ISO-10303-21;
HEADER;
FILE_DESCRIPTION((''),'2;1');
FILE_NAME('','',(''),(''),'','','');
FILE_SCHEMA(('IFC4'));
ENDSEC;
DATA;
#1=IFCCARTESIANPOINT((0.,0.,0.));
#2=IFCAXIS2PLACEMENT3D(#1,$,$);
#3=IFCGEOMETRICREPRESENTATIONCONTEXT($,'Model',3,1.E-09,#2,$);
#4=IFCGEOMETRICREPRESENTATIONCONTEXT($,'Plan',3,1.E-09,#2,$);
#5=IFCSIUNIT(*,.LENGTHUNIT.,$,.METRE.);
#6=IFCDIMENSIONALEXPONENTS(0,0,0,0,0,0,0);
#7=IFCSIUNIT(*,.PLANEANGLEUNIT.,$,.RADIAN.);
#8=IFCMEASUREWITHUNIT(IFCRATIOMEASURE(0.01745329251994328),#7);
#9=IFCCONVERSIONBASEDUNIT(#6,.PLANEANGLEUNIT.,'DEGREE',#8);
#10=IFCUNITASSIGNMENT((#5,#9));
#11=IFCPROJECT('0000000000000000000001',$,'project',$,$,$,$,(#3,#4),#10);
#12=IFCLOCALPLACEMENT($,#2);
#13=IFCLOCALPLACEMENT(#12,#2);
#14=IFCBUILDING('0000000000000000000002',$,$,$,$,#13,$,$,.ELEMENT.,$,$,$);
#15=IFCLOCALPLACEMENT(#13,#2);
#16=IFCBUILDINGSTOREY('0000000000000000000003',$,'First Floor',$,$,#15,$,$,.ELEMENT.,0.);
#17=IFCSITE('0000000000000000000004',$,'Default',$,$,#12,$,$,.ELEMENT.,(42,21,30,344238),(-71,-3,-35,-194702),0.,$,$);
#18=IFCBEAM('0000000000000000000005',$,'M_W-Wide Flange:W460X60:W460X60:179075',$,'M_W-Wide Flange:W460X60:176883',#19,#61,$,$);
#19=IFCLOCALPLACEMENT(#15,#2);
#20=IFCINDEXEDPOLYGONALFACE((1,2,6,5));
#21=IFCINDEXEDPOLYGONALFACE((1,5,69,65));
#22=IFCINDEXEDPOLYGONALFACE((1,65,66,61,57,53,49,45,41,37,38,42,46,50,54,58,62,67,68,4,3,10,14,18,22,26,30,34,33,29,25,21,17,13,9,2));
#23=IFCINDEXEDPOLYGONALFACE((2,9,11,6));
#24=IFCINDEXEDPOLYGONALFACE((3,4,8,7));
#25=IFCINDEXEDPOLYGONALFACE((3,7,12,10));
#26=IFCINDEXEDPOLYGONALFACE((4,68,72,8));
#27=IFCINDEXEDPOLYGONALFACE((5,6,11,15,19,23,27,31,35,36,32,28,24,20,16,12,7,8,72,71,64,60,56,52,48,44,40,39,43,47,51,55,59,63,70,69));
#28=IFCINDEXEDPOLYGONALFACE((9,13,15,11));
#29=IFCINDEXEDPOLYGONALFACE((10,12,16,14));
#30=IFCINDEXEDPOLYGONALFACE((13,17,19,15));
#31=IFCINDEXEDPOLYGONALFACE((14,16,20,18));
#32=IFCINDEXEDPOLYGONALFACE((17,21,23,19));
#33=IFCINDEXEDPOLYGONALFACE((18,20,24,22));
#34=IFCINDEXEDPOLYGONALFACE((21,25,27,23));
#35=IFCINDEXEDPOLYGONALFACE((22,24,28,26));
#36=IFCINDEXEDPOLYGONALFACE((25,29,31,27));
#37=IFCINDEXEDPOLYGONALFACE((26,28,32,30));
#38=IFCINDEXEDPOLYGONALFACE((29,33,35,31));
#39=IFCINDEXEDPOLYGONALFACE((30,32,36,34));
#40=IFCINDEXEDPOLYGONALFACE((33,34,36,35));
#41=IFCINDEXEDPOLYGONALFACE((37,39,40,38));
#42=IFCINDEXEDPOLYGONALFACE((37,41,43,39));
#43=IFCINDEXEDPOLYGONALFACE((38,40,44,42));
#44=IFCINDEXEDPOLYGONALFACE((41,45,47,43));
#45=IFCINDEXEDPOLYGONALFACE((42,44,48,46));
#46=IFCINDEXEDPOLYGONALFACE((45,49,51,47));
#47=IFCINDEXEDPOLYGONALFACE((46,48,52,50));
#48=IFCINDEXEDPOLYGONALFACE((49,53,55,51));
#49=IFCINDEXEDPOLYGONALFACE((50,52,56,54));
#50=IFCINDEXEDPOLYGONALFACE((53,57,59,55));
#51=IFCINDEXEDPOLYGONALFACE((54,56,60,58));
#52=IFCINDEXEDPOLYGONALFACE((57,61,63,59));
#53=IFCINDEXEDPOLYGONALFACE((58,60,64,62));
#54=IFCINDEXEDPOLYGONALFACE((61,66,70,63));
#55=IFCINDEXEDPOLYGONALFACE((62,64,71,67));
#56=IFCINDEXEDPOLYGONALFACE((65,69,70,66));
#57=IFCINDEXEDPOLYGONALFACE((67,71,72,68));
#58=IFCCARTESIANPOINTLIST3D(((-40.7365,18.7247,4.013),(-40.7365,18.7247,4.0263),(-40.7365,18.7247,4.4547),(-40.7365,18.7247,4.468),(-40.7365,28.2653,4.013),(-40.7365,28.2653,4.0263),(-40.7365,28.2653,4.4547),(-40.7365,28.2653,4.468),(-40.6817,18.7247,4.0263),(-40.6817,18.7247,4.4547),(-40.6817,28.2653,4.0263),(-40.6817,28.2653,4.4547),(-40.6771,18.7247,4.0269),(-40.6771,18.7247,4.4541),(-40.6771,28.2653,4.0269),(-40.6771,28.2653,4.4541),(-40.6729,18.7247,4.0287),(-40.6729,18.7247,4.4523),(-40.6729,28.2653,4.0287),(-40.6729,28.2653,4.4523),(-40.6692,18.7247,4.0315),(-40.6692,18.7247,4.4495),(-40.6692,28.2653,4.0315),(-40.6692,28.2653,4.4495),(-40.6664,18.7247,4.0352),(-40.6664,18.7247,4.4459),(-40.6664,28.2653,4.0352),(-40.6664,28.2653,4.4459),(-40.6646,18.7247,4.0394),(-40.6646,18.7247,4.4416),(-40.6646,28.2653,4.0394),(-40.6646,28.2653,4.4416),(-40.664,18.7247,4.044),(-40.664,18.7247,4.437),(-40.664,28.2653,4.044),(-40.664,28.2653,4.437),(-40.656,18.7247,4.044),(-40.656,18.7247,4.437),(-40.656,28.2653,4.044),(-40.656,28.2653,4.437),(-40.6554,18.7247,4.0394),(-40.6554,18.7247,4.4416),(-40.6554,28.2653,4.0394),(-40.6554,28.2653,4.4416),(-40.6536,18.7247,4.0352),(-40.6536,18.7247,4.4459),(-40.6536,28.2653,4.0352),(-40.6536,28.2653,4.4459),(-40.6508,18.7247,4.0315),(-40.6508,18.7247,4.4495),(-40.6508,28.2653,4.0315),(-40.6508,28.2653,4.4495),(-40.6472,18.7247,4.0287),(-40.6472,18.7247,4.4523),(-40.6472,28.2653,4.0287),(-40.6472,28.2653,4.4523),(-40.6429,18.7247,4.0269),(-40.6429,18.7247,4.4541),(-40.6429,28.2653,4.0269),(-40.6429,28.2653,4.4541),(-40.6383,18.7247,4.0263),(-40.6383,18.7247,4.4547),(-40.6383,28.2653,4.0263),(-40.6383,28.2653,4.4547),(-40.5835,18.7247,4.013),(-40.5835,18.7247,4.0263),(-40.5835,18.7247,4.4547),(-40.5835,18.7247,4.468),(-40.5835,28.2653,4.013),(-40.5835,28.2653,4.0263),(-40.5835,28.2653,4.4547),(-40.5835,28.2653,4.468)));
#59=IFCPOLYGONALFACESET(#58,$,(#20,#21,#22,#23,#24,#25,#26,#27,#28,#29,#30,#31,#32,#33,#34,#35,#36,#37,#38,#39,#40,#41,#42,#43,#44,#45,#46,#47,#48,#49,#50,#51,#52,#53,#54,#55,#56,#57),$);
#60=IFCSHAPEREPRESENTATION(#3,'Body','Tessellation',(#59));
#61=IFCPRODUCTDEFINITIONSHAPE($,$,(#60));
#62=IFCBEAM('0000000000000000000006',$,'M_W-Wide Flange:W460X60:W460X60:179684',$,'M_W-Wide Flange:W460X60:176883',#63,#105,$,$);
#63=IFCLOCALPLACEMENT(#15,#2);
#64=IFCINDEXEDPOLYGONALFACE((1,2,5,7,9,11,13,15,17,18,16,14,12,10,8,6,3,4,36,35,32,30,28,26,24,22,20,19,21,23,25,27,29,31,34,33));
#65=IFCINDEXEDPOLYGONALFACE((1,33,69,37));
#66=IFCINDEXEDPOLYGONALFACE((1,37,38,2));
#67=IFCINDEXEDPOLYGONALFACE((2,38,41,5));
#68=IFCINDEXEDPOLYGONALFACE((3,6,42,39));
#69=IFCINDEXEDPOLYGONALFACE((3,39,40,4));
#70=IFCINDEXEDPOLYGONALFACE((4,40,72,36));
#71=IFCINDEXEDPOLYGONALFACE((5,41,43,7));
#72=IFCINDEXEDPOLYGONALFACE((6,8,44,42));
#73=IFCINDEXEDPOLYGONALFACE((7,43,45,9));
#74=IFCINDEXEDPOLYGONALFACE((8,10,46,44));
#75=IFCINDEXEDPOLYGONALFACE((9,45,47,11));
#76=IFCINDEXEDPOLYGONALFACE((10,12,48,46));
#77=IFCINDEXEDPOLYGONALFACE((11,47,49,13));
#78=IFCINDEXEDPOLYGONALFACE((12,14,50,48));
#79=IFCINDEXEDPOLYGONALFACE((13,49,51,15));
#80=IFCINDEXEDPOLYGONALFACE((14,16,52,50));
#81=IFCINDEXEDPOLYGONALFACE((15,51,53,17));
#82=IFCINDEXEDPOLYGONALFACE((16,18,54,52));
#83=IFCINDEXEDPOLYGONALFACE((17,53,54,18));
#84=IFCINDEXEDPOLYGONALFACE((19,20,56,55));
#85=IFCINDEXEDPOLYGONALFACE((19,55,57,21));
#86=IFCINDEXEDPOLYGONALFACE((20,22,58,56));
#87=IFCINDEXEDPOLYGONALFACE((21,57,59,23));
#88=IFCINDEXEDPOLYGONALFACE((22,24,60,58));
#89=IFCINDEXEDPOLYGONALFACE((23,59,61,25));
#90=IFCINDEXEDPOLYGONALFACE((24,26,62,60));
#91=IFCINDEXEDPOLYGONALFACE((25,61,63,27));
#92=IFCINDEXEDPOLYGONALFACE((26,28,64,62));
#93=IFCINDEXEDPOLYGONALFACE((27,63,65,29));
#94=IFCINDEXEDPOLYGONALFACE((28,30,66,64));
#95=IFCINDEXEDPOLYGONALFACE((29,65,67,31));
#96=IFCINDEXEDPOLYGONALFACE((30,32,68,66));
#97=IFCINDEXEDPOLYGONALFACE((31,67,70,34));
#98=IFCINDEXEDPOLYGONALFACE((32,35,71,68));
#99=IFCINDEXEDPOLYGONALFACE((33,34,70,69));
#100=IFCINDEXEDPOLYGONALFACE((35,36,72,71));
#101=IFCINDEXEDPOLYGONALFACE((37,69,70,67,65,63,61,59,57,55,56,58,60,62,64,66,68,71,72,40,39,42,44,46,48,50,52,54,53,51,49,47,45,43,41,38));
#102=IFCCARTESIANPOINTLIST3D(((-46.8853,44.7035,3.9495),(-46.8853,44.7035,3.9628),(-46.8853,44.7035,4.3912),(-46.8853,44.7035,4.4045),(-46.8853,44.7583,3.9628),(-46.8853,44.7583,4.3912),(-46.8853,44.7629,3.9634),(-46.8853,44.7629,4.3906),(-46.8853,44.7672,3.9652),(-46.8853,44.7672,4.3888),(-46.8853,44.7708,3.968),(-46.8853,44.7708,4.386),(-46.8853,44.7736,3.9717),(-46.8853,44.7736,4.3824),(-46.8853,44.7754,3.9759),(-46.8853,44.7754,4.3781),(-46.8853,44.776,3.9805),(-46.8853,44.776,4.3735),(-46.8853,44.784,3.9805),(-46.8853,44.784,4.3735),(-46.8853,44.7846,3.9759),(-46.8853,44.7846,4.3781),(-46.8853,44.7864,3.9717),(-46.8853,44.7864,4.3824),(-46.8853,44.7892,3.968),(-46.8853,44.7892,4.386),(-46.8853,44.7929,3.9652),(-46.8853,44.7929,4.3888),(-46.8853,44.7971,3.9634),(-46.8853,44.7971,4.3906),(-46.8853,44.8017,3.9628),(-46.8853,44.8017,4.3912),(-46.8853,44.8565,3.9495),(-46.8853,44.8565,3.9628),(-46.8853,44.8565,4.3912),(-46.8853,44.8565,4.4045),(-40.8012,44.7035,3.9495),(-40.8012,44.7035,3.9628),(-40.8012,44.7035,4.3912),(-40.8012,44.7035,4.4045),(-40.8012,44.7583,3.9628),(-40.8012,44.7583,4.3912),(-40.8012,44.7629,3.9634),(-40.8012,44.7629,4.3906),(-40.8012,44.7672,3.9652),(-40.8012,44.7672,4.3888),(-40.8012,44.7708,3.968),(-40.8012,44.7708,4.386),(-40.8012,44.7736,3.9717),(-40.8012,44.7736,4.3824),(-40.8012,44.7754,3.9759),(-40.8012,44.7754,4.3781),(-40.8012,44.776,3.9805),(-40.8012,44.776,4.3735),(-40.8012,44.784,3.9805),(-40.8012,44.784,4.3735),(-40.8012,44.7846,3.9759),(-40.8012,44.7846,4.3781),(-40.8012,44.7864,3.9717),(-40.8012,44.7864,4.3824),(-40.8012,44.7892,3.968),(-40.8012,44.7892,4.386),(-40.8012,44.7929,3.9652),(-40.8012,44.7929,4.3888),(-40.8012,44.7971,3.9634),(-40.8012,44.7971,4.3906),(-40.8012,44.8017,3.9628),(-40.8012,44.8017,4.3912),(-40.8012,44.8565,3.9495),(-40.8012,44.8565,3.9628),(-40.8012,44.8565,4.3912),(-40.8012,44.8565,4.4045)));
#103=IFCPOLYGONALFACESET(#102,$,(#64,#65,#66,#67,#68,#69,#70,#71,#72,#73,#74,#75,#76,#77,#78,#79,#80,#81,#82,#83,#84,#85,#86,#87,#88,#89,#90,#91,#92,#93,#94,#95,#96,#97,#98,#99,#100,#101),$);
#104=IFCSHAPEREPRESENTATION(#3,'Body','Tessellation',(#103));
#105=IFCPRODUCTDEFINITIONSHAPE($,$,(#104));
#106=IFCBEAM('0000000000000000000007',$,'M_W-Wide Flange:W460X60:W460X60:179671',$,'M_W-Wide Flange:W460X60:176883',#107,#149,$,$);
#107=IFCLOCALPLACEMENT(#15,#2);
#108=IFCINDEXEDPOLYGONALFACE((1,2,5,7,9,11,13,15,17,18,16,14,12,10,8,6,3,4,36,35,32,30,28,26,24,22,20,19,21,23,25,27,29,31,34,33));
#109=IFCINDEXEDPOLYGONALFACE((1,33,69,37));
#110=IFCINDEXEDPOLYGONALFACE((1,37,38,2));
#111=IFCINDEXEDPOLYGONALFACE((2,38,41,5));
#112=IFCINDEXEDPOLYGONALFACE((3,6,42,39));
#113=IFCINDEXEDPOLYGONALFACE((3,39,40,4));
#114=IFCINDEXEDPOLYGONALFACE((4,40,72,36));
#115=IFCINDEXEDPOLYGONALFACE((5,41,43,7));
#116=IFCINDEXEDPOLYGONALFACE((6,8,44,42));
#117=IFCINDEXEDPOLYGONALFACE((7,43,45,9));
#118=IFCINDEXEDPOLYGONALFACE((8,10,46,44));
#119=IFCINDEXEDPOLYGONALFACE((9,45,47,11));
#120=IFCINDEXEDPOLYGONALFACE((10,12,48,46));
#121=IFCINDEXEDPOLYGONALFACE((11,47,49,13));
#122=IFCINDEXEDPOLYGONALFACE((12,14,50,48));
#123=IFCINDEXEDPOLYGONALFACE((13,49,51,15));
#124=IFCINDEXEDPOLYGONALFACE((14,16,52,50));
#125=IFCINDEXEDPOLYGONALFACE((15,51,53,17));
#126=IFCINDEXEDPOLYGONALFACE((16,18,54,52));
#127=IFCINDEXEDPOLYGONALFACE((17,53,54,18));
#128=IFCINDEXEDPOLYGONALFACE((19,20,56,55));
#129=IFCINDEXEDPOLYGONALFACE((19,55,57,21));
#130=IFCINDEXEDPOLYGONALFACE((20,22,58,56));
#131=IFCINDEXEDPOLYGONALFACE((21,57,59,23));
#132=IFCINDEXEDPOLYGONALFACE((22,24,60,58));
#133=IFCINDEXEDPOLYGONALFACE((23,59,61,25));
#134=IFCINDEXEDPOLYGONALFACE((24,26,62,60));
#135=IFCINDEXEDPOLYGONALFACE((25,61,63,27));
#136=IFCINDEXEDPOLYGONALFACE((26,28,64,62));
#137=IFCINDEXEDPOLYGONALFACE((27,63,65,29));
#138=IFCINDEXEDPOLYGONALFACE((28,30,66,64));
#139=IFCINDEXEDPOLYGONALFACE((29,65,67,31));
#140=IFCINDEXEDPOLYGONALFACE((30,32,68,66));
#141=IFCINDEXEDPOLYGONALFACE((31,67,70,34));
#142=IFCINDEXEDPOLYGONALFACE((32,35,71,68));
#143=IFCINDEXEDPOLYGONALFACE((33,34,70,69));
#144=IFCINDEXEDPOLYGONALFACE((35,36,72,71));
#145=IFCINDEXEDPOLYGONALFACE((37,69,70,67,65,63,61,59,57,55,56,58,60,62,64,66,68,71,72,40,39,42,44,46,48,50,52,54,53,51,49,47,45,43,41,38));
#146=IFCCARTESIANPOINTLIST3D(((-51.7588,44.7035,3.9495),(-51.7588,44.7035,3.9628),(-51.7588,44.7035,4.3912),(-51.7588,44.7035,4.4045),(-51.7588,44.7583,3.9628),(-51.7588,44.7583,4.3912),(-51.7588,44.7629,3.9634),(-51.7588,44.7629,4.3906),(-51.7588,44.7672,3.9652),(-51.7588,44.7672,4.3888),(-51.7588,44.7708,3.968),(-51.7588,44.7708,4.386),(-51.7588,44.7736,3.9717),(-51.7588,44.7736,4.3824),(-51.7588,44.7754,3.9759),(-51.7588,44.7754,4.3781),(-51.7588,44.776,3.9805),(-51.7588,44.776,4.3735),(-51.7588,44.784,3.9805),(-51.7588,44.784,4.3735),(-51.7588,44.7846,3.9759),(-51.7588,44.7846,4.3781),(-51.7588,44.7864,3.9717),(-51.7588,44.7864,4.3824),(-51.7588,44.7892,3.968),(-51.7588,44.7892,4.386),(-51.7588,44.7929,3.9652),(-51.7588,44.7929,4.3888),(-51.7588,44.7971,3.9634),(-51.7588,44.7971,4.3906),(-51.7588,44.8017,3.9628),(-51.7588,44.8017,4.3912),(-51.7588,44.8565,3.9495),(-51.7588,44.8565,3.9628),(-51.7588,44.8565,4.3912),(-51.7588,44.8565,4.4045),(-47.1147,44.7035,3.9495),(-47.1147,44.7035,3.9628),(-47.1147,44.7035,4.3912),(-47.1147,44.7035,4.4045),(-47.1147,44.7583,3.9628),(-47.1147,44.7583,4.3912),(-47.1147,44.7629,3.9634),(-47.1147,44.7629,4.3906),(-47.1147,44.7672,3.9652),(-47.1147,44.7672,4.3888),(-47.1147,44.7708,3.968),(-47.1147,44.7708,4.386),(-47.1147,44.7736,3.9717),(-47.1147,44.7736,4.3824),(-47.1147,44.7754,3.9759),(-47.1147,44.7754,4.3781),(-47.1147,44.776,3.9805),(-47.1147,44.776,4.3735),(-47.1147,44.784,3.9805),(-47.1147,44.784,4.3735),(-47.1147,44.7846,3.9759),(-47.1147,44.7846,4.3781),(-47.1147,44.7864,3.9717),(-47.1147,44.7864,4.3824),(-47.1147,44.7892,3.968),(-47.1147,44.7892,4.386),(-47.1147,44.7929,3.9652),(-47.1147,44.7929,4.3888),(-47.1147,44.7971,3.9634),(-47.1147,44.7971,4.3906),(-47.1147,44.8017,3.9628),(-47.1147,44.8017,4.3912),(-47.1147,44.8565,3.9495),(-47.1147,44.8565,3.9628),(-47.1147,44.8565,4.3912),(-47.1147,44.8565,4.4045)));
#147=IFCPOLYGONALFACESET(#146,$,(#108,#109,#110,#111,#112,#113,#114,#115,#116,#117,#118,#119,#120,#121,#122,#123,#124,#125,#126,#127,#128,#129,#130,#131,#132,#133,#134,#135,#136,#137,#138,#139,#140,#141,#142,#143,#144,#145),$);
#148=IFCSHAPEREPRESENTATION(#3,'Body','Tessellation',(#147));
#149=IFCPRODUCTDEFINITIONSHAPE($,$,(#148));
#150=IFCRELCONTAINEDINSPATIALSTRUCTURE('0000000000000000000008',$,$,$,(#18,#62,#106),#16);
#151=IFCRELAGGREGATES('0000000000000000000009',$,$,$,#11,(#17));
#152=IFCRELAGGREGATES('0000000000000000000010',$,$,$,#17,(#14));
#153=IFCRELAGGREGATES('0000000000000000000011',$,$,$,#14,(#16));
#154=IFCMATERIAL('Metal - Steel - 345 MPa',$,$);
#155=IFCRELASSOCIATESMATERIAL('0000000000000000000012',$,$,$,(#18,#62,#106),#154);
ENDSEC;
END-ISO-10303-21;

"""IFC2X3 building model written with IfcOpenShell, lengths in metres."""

from ifc_helpers import new_model, entity, si_unit, converted_unit, frame, frame_2d, origin, place, context, project, spatial, polyline, circle_curve, parameter, trimmed, segment, composite_curve, outline, extrude, material, element, save


model = new_model("IFC2X3")

# Units and contexts
model_context = context("Model", 3, precision=1e-09, world=origin())
plan_context = context("Plan", 3, precision=1e-09, world=origin())
ifc_project = project(units=[si_unit("LENGTHUNIT", "METRE"), converted_unit("PLANEANGLEUNIT", "DEGREE", entity("IfcRatioMeasure", 0.01745329251994328), si_unit("PLANEANGLEUNIT", "RADIAN"), dimensions=[0, 0, 0, 0, 0, 0, 0])], contexts=[model_context, plan_context])

# Site, building, storey
site_placement = place(None, origin())
site = spatial("IfcSite", under=ifc_project, at=site_placement, Name="Default", CompositionType="ELEMENT", RefLatitude=(42, 21, 30, 344238), RefLongitude=(-71, -3, -35, -194702), RefElevation=0.0)
building_placement = place(site_placement, origin())
building = spatial("IfcBuilding", under=site, at=building_placement, CompositionType="ELEMENT")
storey_placement = place(building_placement, origin())
storey = spatial("IfcBuildingStorey", under=building, at=storey_placement, Name="First Floor", CompositionType="ELEMENT", Elevation=0.0)

# Beams
ifc_material = material(Name="Metal - Steel - 345 MPa")
beam_1_placement = place(storey_placement, frame((-40.66, 28.3814, 4.468), z_axis=(0.0, 0.0, 1.0), x_axis=(-1.0, 0.0, 0.0)))
element("IfcBeam", 1, at=beam_1_placement, inside=storey, material=ifc_material, Name="M_W-Wide Flange:W460X60:W460X60:179075", ObjectType="M_W-Wide Flange:W460X60:176883", context=model_context, shape_type="SweptSolid", body=[
    extrude(outline(composite_curve([segment(polyline([(0.2142, -0.0765), (0.2275, -0.0765)]), True, "CONTINUOUS"), segment(polyline([(0.2275, -0.0765), (0.2275, 0.0765)]), True, "CONTINUOUS"), segment(polyline([(0.2275, 0.0765), (0.2142, 0.0765)]), True, "CONTINUOUS"), segment(polyline([(0.2142, 0.0765), (0.2142, 0.0217)]), True, "CONTINUOUS"), segment(trimmed(circle_curve(frame_2d((0.1965, 0.0217), x_axis=(1.0, 0.0)), 0.0177), [parameter(270.0)], [parameter(360.0)], True, "PARAMETER"), False, "CONTINUOUS"), segment(polyline([(0.1965, 0.004), (-0.1965, 0.004)]), True, "CONTINUOUS"), segment(trimmed(circle_curve(frame_2d((-0.1965, 0.0217), x_axis=(0.0, -1.0)), 0.0177), [parameter(270.0)], [parameter(360.0)], True, "PARAMETER"), False, "CONTINUOUS"), segment(polyline([(-0.2142, 0.0217), (-0.2142, 0.0765)]), True, "CONTINUOUS"), segment(polyline([(-0.2142, 0.0765), (-0.2275, 0.0765)]), True, "CONTINUOUS"), segment(polyline([(-0.2275, 0.0765), (-0.2275, -0.0765)]), True, "CONTINUOUS"), segment(polyline([(-0.2275, -0.0765), (-0.2142, -0.0765)]), True, "CONTINUOUS"), segment(polyline([(-0.2142, -0.0765), (-0.2142, -0.0217)]), True, "CONTINUOUS"), segment(trimmed(circle_curve(frame_2d((-0.1965, -0.0217), x_axis=(-1.0, 0.0)), 0.0177), [parameter(270.0)], [parameter(360.0)], True, "PARAMETER"), False, "CONTINUOUS"), segment(polyline([(-0.1965, -0.004), (0.1965, -0.004)]), True, "CONTINUOUS"), segment(trimmed(circle_curve(frame_2d((0.1965, -0.0217), x_axis=(0.0, 1.0)), 0.0177), [parameter(270.0)], [parameter(0.0)], True, "PARAMETER"), False, "CONTINUOUS"), segment(polyline([(0.2142, -0.0217), (0.2142, -0.0765)]), True, "CONTINUOUS")], self_intersect=False)), frame((0.0, 9.6567, -0.2275), z_axis=(0.0, -1.0, 0.0), x_axis=(0.0, 0.0, -1.0)), (0.0, 0.0, 1.0), 9.5406),
])
beam_2_placement = place(storey_placement, frame((-47.0022, 44.78, 4.4045), z_axis=(0.0, 0.0, 1.0), x_axis=(0.0, -1.0, 0.0)))
element("IfcBeam", 2, at=beam_2_placement, inside=storey, material=ifc_material, Name="M_W-Wide Flange:W460X60:W460X60:179684", ObjectType="M_W-Wide Flange:W460X60:176883", context=model_context, shape_type="SweptSolid", body=[
    extrude(outline(composite_curve([segment(polyline([(-0.0765, -0.2142), (-0.0765, -0.2275)]), True, "CONTINUOUS"), segment(polyline([(-0.0765, -0.2275), (0.0765, -0.2275)]), True, "CONTINUOUS"), segment(polyline([(0.0765, -0.2275), (0.0765, -0.2142)]), True, "CONTINUOUS"), segment(polyline([(0.0765, -0.2142), (0.0217, -0.2142)]), True, "CONTINUOUS"), segment(trimmed(circle_curve(frame_2d((0.0217, -0.1965), x_axis=(0.0, -1.0)), 0.0177), [parameter(270.0)], [parameter(360.0)], True, "PARAMETER"), False, "CONTINUOUS"), segment(polyline([(0.004, -0.1965), (0.004, 0.1965)]), True, "CONTINUOUS"), segment(trimmed(circle_curve(frame_2d((0.0217, 0.1965), x_axis=(-1.0, 0.0)), 0.0177), [parameter(270.0)], [parameter(360.0)], True, "PARAMETER"), False, "CONTINUOUS"), segment(polyline([(0.0217, 0.2142), (0.0765, 0.2142)]), True, "CONTINUOUS"), segment(polyline([(0.0765, 0.2142), (0.0765, 0.2275)]), True, "CONTINUOUS"), segment(polyline([(0.0765, 0.2275), (-0.0765, 0.2275)]), True, "CONTINUOUS"), segment(polyline([(-0.0765, 0.2275), (-0.0765, 0.2142)]), True, "CONTINUOUS"), segment(polyline([(-0.0765, 0.2142), (-0.0217, 0.2142)]), True, "CONTINUOUS"), segment(trimmed(circle_curve(frame_2d((-0.0217, 0.1965), x_axis=(0.0, 1.0)), 0.0177), [parameter(270.0)], [parameter(360.0)], True, "PARAMETER"), False, "CONTINUOUS"), segment(polyline([(-0.004, 0.1965), (-0.004, -0.1965)]), True, "CONTINUOUS"), segment(trimmed(circle_curve(frame_2d((-0.0217, -0.1965), x_axis=(1.0, 0.0)), 0.0177), [parameter(270.0)], [parameter(0.0)], True, "PARAMETER"), False, "CONTINUOUS"), segment(polyline([(-0.0217, -0.2142), (-0.0765, -0.2142)]), True, "CONTINUOUS")], self_intersect=False)), frame((0.0, 0.1169, -0.2275), z_axis=(0.0, -1.0, 0.0), x_axis=(1.0, 0.0, 0.0)), (0.0, 0.0, -1.0), 6.0841),
])
beam_3_placement = place(storey_placement, frame((-51.9028, 44.78, 4.4045), z_axis=(0.0, 0.0, 1.0), x_axis=(0.0, -1.0, 0.0)))
element("IfcBeam", 3, at=beam_3_placement, inside=storey, material=ifc_material, Name="M_W-Wide Flange:W460X60:W460X60:179671", ObjectType="M_W-Wide Flange:W460X60:176883", context=model_context, shape_type="SweptSolid", body=[
    extrude(outline(composite_curve([segment(polyline([(-0.0765, -0.2142), (-0.0765, -0.2275)]), True, "CONTINUOUS"), segment(polyline([(-0.0765, -0.2275), (0.0765, -0.2275)]), True, "CONTINUOUS"), segment(polyline([(0.0765, -0.2275), (0.0765, -0.2142)]), True, "CONTINUOUS"), segment(polyline([(0.0765, -0.2142), (0.0217, -0.2142)]), True, "CONTINUOUS"), segment(trimmed(circle_curve(frame_2d((0.0217, -0.1965), x_axis=(1.0, 0.0)), 0.0177), [parameter(180.0)], [parameter(270.0)], True, "PARAMETER"), False, "CONTINUOUS"), segment(polyline([(0.004, -0.1965), (0.004, 0.1965)]), True, "CONTINUOUS"), segment(trimmed(circle_curve(frame_2d((0.0217, 0.1965), x_axis=(1.0, 0.0)), 0.0177), [parameter(90.0)], [parameter(180.0)], True, "PARAMETER"), False, "CONTINUOUS"), segment(polyline([(0.0217, 0.2142), (0.0765, 0.2142)]), True, "CONTINUOUS"), segment(polyline([(0.0765, 0.2142), (0.0765, 0.2275)]), True, "CONTINUOUS"), segment(polyline([(0.0765, 0.2275), (-0.0765, 0.2275)]), True, "CONTINUOUS"), segment(polyline([(-0.0765, 0.2275), (-0.0765, 0.2142)]), True, "CONTINUOUS"), segment(polyline([(-0.0765, 0.2142), (-0.0217, 0.2142)]), True, "CONTINUOUS"), segment(trimmed(circle_curve(frame_2d((-0.0217, 0.1965), x_axis=(1.0, 0.0)), 0.0177), [parameter(360.0)], [parameter(90.0)], True, "PARAMETER"), False, "CONTINUOUS"), segment(polyline([(-0.004, 0.1965), (-0.004, -0.1965)]), True, "CONTINUOUS"), segment(trimmed(circle_curve(frame_2d((-0.0217, -0.1965), x_axis=(1.0, 0.0)), 0.0177), [parameter(270.0)], [parameter(0.0)], True, "PARAMETER"), False, "CONTINUOUS"), segment(polyline([(-0.0217, -0.2142), (-0.0765, -0.2142)]), True, "CONTINUOUS")], self_intersect=False)), frame((0.0, 0.144, -0.2275), z_axis=(0.0, -1.0, 0.0), x_axis=(1.0, 0.0, 0.0)), (0.0, 0.0, -1.0), 4.6441),
])

save(model, "model.ifc")
